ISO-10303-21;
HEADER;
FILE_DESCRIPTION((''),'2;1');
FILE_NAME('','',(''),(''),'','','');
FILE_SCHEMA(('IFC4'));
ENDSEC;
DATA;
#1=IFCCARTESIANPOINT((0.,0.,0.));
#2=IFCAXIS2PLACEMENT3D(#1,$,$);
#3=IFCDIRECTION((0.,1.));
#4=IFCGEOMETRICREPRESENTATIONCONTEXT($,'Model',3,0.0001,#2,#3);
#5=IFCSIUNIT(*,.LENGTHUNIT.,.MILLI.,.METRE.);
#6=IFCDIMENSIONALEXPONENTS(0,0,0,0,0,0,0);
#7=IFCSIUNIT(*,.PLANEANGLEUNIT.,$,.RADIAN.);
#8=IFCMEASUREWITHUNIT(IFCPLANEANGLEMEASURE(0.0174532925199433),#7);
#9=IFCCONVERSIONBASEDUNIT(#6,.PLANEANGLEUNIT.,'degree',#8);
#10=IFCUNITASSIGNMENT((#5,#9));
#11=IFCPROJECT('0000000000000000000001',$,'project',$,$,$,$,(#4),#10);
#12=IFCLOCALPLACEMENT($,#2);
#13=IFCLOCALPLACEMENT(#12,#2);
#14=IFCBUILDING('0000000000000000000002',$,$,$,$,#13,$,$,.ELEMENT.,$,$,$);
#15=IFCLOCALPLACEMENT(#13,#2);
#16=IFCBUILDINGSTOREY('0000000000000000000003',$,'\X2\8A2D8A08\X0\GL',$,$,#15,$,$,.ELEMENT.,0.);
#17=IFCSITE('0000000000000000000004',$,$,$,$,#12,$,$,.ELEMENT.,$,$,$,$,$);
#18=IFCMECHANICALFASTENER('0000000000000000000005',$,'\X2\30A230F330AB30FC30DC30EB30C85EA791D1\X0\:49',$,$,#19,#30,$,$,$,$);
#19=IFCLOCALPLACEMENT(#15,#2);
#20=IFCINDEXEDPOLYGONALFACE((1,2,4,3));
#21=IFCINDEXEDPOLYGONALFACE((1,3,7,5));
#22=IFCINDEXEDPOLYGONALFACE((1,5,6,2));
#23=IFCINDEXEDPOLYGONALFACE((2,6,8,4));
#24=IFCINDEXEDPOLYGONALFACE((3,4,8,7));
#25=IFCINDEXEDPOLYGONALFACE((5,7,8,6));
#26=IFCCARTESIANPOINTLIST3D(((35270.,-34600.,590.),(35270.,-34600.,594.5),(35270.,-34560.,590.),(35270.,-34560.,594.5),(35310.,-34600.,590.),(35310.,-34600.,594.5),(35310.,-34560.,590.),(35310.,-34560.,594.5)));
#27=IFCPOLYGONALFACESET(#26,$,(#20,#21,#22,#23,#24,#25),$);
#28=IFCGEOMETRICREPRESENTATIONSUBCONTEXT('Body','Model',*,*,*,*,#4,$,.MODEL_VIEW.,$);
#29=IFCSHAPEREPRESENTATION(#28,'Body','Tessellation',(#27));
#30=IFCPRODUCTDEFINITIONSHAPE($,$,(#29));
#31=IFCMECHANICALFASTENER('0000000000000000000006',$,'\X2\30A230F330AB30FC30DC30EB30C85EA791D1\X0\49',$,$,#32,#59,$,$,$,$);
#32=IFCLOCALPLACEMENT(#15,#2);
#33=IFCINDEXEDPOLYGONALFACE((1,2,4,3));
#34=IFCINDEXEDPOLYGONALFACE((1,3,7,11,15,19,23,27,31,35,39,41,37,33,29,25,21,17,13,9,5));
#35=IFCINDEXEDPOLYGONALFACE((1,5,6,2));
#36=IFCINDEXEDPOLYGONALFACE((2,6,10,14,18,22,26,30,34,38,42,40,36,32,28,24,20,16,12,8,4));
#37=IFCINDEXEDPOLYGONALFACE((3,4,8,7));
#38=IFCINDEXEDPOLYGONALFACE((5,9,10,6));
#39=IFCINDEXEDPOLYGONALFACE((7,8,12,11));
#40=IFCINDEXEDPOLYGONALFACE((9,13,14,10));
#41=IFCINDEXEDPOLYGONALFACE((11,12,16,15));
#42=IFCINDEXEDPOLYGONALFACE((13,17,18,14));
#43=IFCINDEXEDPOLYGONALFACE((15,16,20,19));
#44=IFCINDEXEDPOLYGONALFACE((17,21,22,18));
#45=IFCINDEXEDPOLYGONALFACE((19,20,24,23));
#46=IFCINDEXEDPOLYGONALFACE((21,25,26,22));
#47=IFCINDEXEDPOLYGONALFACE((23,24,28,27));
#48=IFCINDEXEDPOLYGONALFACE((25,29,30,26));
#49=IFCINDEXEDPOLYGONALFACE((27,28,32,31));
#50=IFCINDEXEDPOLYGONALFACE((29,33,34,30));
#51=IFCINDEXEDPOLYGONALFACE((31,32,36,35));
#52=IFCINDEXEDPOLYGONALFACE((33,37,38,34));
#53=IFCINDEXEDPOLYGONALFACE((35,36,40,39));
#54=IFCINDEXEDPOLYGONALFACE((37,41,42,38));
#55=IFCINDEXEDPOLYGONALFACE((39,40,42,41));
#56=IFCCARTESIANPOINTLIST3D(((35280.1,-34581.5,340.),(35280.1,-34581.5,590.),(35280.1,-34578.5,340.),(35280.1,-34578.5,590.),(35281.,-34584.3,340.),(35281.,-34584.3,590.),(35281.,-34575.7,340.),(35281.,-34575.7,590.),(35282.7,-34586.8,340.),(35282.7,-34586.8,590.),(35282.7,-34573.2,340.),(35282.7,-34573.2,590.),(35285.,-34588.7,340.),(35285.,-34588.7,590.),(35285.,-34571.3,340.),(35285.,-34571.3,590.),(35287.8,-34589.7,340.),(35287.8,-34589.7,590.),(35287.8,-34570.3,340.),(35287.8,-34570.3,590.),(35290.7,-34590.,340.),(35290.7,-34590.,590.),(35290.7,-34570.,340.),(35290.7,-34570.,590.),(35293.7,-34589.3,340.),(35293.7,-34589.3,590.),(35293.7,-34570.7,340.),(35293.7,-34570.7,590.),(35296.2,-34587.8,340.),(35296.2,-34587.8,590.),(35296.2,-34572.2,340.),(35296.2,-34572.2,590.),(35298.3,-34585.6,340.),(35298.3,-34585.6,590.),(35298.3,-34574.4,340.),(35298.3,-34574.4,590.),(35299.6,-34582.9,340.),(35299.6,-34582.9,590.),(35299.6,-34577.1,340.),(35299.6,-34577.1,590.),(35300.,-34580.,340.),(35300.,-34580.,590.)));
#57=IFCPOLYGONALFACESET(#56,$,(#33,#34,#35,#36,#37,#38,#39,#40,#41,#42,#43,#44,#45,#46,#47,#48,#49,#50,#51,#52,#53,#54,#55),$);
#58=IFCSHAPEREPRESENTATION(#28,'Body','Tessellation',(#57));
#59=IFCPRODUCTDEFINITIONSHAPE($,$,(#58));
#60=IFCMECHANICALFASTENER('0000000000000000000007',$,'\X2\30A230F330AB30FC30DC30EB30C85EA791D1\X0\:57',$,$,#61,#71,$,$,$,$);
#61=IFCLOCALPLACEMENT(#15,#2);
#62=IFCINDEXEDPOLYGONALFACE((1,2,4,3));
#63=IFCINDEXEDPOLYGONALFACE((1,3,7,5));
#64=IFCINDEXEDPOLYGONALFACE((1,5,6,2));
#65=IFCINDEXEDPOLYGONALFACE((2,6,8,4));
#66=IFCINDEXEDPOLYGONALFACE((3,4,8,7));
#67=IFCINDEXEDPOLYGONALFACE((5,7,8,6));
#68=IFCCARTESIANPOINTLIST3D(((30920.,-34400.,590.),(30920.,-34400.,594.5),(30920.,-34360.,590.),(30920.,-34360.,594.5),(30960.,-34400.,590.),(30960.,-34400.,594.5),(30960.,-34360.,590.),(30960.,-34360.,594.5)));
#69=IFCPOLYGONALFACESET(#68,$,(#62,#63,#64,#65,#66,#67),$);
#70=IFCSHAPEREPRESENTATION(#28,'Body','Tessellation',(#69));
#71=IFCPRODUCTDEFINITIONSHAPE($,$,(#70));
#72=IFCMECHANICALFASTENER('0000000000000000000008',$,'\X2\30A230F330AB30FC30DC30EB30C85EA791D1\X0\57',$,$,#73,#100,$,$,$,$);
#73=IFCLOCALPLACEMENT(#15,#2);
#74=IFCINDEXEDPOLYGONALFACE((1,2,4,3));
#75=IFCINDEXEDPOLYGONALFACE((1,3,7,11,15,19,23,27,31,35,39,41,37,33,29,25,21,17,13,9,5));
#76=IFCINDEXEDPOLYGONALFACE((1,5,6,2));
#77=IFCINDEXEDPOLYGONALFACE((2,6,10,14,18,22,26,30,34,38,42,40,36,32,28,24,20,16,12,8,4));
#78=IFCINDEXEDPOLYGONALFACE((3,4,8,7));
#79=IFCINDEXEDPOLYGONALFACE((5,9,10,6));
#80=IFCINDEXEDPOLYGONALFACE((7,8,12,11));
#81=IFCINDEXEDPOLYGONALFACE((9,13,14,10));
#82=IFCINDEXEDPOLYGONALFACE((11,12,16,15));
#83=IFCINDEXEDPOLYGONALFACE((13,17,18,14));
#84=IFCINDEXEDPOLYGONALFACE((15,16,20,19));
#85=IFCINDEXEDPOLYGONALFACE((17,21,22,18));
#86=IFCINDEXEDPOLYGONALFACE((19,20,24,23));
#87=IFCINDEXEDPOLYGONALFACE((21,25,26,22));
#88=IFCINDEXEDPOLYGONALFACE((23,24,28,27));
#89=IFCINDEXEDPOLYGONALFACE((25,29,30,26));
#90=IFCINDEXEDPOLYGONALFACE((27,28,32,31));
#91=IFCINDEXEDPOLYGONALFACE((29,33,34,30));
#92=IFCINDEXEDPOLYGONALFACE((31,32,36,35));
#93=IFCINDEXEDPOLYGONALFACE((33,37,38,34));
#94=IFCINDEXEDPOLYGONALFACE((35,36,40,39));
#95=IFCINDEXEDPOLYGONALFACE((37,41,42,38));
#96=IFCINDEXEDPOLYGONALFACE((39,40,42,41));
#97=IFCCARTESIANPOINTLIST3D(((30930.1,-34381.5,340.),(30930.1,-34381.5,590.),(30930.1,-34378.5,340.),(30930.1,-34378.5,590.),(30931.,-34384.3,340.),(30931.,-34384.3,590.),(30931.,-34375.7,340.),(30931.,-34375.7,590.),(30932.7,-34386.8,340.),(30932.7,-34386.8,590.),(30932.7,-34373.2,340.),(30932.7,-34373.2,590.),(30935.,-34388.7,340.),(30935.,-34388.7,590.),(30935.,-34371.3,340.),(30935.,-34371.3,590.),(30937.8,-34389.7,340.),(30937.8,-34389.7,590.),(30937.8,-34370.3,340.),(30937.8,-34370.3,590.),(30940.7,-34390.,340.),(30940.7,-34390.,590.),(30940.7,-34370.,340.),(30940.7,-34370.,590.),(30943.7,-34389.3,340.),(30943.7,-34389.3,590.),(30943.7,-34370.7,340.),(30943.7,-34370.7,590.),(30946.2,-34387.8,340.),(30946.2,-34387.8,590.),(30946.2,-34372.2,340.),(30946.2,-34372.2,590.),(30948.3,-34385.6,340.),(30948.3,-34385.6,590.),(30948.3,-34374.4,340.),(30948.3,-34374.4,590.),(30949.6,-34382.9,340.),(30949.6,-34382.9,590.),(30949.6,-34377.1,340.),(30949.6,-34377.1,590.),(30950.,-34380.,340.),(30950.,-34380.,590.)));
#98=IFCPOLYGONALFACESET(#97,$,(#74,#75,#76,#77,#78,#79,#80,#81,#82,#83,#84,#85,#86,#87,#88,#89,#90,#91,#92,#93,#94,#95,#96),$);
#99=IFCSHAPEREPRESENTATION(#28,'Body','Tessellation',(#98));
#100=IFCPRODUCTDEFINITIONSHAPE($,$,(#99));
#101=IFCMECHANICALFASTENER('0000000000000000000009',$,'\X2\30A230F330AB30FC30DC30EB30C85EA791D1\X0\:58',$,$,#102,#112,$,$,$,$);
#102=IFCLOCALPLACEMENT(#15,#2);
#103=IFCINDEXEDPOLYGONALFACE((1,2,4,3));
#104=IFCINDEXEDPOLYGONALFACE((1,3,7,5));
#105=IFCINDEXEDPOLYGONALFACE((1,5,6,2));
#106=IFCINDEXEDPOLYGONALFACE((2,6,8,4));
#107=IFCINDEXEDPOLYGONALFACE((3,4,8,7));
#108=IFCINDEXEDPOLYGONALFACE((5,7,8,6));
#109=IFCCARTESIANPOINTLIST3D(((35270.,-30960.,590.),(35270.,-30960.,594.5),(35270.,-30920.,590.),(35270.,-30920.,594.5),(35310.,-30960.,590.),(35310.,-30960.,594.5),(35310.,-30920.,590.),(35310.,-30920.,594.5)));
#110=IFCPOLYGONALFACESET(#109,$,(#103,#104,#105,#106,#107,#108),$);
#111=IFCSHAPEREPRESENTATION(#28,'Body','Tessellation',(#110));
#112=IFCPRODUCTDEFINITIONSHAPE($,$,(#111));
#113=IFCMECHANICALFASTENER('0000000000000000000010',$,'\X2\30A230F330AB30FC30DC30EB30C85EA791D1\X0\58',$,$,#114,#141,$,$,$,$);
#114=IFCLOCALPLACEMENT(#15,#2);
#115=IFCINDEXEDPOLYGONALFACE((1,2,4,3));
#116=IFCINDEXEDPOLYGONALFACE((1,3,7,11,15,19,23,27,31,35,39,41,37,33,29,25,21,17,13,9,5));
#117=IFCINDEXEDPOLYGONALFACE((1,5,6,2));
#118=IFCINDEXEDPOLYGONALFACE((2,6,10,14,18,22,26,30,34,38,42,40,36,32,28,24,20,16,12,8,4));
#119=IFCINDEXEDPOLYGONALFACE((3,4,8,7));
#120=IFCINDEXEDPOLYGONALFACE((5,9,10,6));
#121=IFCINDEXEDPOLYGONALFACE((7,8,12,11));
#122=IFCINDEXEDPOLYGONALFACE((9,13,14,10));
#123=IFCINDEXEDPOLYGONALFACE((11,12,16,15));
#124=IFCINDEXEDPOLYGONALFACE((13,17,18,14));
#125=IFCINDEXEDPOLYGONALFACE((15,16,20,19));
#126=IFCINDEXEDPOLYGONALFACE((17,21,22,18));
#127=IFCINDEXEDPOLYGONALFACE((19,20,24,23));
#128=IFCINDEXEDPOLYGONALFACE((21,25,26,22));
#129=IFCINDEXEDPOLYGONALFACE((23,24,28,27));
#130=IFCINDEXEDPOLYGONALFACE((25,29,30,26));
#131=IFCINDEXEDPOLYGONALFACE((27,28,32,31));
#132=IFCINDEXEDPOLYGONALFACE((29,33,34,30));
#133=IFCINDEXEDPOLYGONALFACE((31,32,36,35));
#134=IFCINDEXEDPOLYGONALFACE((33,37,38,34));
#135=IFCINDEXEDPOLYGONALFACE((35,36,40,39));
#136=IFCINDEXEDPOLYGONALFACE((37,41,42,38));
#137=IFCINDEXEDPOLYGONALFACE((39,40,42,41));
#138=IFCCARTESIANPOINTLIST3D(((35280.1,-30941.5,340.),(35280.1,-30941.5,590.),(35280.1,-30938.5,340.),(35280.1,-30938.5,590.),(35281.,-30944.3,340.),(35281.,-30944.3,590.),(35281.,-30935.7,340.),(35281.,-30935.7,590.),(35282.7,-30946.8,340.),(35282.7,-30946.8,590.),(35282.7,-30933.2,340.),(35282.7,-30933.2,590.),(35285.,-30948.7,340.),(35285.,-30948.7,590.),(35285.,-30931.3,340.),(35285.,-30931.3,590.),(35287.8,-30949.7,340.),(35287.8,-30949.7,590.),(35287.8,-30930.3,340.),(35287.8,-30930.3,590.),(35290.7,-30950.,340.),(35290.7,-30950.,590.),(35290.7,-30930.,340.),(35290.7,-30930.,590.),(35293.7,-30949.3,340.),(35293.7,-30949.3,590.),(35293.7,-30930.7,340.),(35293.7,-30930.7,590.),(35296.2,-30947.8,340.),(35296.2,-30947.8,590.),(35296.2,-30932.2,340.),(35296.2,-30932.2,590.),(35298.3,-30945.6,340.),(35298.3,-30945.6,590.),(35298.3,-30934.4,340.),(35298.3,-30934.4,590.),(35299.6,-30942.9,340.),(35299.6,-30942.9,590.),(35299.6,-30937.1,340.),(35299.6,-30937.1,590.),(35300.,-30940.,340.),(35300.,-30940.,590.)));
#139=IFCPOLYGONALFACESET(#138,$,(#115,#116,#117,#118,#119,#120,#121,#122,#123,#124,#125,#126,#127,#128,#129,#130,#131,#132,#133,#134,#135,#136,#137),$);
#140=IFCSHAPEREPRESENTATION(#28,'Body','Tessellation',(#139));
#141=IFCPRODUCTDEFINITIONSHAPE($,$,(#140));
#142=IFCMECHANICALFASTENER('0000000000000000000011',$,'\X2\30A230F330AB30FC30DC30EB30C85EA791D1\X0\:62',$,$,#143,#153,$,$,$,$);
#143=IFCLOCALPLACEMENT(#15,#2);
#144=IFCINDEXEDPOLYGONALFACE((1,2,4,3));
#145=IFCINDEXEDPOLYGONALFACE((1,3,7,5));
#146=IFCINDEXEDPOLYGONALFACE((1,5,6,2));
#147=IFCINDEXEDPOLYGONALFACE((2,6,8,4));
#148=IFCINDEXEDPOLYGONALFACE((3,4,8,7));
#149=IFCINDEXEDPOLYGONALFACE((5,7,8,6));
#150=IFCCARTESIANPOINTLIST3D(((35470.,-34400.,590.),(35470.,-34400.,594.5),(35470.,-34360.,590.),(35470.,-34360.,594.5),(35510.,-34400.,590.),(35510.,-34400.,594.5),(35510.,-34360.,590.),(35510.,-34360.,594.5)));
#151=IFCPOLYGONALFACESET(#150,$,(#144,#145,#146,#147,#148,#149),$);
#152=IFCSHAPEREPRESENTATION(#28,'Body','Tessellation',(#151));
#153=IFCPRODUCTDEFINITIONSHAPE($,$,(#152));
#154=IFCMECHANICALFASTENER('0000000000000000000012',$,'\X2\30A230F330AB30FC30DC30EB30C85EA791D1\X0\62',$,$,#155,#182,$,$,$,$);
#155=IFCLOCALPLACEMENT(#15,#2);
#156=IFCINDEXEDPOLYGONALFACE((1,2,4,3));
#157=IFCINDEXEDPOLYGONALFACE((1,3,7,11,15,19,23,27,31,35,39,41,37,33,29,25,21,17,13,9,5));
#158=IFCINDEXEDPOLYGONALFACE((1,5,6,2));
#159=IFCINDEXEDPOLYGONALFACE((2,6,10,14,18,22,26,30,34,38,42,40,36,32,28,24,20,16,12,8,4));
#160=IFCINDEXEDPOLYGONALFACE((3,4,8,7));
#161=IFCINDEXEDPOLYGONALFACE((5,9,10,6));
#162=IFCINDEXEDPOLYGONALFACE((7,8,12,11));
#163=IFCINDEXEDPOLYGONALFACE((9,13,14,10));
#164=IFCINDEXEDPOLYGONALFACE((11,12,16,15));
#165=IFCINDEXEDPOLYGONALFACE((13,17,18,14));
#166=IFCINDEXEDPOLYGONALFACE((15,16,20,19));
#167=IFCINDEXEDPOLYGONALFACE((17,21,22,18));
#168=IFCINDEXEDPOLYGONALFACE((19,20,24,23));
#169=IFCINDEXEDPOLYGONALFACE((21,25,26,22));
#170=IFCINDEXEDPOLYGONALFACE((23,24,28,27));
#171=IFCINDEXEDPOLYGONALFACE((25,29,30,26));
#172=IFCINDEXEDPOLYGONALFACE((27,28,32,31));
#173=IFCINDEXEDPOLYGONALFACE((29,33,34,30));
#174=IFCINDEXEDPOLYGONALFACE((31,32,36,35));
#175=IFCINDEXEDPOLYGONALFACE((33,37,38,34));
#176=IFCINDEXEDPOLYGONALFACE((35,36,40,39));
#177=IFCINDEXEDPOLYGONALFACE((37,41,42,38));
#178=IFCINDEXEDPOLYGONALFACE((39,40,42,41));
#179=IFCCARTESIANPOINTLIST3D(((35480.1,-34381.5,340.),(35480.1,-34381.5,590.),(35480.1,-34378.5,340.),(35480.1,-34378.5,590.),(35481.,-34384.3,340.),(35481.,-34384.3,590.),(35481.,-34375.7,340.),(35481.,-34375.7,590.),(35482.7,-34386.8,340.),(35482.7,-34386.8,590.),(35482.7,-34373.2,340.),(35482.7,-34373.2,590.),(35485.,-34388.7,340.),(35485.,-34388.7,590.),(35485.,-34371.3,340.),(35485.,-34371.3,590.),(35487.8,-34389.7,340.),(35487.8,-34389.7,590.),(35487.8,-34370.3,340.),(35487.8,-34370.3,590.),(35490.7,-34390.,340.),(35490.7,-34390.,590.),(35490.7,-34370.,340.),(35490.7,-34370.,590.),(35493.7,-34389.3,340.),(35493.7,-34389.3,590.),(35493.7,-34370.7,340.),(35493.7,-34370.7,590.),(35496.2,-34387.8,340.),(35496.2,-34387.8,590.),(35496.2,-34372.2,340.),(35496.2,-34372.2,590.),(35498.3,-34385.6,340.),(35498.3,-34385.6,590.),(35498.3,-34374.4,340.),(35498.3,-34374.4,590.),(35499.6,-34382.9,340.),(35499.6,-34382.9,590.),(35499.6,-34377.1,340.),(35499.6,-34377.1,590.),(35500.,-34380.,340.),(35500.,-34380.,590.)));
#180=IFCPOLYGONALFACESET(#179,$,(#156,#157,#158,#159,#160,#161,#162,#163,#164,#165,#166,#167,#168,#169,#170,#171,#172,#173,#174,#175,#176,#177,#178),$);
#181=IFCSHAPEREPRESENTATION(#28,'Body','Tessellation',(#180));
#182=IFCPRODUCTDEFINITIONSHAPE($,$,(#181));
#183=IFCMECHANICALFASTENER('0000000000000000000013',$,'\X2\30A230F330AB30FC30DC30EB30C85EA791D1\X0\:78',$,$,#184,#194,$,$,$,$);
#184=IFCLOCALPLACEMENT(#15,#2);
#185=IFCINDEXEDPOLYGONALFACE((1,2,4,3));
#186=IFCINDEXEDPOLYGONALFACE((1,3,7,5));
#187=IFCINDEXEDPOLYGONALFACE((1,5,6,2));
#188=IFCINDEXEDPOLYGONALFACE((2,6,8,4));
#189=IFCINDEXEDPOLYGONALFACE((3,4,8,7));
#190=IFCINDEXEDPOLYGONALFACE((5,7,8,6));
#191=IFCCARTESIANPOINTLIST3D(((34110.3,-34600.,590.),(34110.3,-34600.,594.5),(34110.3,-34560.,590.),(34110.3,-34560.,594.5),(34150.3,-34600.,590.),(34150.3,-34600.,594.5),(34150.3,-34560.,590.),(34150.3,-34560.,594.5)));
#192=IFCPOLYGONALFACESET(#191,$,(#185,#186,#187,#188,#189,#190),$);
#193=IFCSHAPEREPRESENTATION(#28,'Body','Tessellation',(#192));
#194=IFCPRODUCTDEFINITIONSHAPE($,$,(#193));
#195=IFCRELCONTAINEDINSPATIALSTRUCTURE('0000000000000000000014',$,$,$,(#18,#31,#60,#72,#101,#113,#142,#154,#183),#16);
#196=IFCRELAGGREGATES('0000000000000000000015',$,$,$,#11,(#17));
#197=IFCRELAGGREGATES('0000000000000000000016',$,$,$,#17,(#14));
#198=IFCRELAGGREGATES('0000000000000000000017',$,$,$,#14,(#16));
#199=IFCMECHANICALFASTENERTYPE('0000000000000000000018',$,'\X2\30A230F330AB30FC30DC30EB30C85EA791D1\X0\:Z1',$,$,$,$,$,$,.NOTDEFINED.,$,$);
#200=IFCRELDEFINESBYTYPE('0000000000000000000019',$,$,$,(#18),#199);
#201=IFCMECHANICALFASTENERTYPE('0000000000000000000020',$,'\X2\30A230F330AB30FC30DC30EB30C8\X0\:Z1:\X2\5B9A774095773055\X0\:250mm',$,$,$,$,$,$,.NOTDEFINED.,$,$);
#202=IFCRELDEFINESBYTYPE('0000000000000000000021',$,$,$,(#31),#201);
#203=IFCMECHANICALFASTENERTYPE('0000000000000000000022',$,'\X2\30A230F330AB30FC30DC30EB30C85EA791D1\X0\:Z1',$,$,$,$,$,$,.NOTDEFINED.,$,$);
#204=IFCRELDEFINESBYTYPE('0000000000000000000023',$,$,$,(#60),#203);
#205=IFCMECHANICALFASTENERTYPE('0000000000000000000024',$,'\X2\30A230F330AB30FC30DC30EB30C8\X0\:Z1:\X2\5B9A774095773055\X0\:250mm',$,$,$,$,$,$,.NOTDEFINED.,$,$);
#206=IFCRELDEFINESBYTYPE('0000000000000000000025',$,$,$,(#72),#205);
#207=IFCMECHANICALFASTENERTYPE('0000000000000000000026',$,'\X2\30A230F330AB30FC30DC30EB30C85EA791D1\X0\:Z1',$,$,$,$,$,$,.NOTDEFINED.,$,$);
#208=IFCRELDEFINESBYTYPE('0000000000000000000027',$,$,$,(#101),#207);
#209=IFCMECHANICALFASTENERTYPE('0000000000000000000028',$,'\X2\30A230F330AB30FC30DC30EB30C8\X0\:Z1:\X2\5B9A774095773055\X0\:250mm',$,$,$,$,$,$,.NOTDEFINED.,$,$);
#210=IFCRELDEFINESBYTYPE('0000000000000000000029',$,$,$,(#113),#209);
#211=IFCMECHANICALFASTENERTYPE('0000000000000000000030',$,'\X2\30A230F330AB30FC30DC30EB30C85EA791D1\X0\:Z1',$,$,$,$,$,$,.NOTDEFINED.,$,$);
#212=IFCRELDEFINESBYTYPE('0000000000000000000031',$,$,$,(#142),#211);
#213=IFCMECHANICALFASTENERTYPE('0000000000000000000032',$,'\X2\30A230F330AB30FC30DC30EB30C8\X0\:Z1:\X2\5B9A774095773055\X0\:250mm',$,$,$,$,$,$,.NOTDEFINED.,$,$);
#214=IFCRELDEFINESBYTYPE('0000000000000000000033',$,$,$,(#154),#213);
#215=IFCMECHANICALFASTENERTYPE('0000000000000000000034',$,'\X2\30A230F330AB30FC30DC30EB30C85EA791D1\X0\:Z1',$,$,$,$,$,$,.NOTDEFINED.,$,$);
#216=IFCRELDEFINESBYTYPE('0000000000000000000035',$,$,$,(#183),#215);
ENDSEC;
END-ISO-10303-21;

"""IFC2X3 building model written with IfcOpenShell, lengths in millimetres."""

from ifc_helpers import new_model, entity, si_unit, converted_unit, direction, frame, origin, origin_with_axes, origin_2d, place, context, subcontext, project, spatial, rectangle, circle, extrude, type_object, element, save


model = new_model("IFC2X3")

# Units and contexts
model_context = context("Model", 3, precision=0.0001, world=origin(), true_north=direction((0.0, 1.0)))
body_context = subcontext(model_context, "Body", "Model", "MODEL_VIEW")
ifc_project = project(units=[si_unit("LENGTHUNIT", "METRE", prefix="MILLI"), converted_unit("PLANEANGLEUNIT", "degree", entity("IfcPlaneAngleMeasure", 0.0174532925199433), si_unit("PLANEANGLEUNIT", "RADIAN"), dimensions=[0, 0, 0, 0, 0, 0, 0])], contexts=[model_context])

# Site, building, storey
site_placement = place(None, origin())
site = spatial("IfcSite", under=ifc_project, at=site_placement, CompositionType="ELEMENT")
building_placement = place(site_placement, origin())
building = spatial("IfcBuilding", under=site, at=building_placement, CompositionType="ELEMENT")
storey_placement = place(building_placement, origin())
storey = spatial("IfcBuildingStorey", under=building, at=storey_placement, Name="設計GL", CompositionType="ELEMENT", Elevation=0.0)

# Mechanical fasteners
mechanical_fastener_type_1 = type_object("IfcMechanicalFastenerType", Name="アンカーボルト座金:Z1")
mechanical_fastener_1_placement = place(storey_placement, frame((35290.0, -34580.0, 590.0)))
element("IfcMechanicalFastener", 1, at=mechanical_fastener_1_placement, inside=storey, type_object=mechanical_fastener_type_1, Name="アンカーボルト座金:49", context=body_context, shape_type="SweptSolid", body=[
    extrude(rectangle(XDim=40.0, YDim=40.0, at=origin_2d()), origin_with_axes(), (0.0, 0.0, 1.0), 4.5),
])
mechanical_fastener_type_2 = type_object("IfcMechanicalFastenerType", Name="アンカーボルト:Z1:定着長さ:250mm")
mechanical_fastener_2_placement = place(storey_placement, frame((35290.0, -34580.0, 340.0)))
element("IfcMechanicalFastener", 2, at=mechanical_fastener_2_placement, inside=storey, type_object=mechanical_fastener_type_2, Name="アンカーボルト座金49", context=body_context, shape_type="SweptSolid", body=[
    extrude(circle(Radius=10.0, at=origin_2d()), origin_with_axes(), (0.0, 0.0, 1.0), 250.0),
])
mechanical_fastener_type_3 = type_object("IfcMechanicalFastenerType", Name="アンカーボルト座金:Z1")
mechanical_fastener_3_placement = place(storey_placement, frame((30940.0, -34380.0, 590.0)))
element("IfcMechanicalFastener", 3, at=mechanical_fastener_3_placement, inside=storey, type_object=mechanical_fastener_type_3, Name="アンカーボルト座金:57", context=body_context, shape_type="SweptSolid", body=[
    extrude(rectangle(XDim=40.0, YDim=40.0, at=origin_2d()), origin_with_axes(), (0.0, 0.0, 1.0), 4.5),
])
mechanical_fastener_type_4 = type_object("IfcMechanicalFastenerType", Name="アンカーボルト:Z1:定着長さ:250mm")
mechanical_fastener_4_placement = place(storey_placement, frame((30940.0, -34380.0, 340.0)))
element("IfcMechanicalFastener", 4, at=mechanical_fastener_4_placement, inside=storey, type_object=mechanical_fastener_type_4, Name="アンカーボルト座金57", context=body_context, shape_type="SweptSolid", body=[
    extrude(circle(Radius=10.0, at=origin_2d()), origin_with_axes(), (0.0, 0.0, 1.0), 250.0),
])
mechanical_fastener_type_5 = type_object("IfcMechanicalFastenerType", Name="アンカーボルト座金:Z1")
mechanical_fastener_5_placement = place(storey_placement, frame((35290.0, -30940.0, 590.0)))
element("IfcMechanicalFastener", 5, at=mechanical_fastener_5_placement, inside=storey, type_object=mechanical_fastener_type_5, Name="アンカーボルト座金:58", context=body_context, shape_type="SweptSolid", body=[
    extrude(rectangle(XDim=40.0, YDim=40.0, at=origin_2d()), origin_with_axes(), (0.0, 0.0, 1.0), 4.5),
])
mechanical_fastener_type_6 = type_object("IfcMechanicalFastenerType", Name="アンカーボルト:Z1:定着長さ:250mm")
mechanical_fastener_6_placement = place(storey_placement, frame((35290.0, -30940.0, 340.0)))
element("IfcMechanicalFastener", 6, at=mechanical_fastener_6_placement, inside=storey, type_object=mechanical_fastener_type_6, Name="アンカーボルト座金58", context=body_context, shape_type="SweptSolid", body=[
    extrude(circle(Radius=10.0, at=origin_2d()), origin_with_axes(), (0.0, 0.0, 1.0), 250.0),
])
mechanical_fastener_type_7 = type_object("IfcMechanicalFastenerType", Name="アンカーボルト座金:Z1")
mechanical_fastener_7_placement = place(storey_placement, frame((35490.0, -34380.0, 590.0)))
element("IfcMechanicalFastener", 7, at=mechanical_fastener_7_placement, inside=storey, type_object=mechanical_fastener_type_7, Name="アンカーボルト座金:62", context=body_context, shape_type="SweptSolid", body=[
    extrude(rectangle(XDim=40.0, YDim=40.0, at=origin_2d()), origin_with_axes(), (0.0, 0.0, 1.0), 4.5),
])
mechanical_fastener_type_8 = type_object("IfcMechanicalFastenerType", Name="アンカーボルト:Z1:定着長さ:250mm")
mechanical_fastener_8_placement = place(storey_placement, frame((35490.0, -34380.0, 340.0)))
element("IfcMechanicalFastener", 8, at=mechanical_fastener_8_placement, inside=storey, type_object=mechanical_fastener_type_8, Name="アンカーボルト座金62", context=body_context, shape_type="SweptSolid", body=[
    extrude(circle(Radius=10.0, at=origin_2d()), origin_with_axes(), (0.0, 0.0, 1.0), 250.0),
])
mechanical_fastener_type_9 = type_object("IfcMechanicalFastenerType", Name="アンカーボルト座金:Z1")
mechanical_fastener_9_placement = place(storey_placement, frame((34130.3, -34580.0, 590.0)))
element("IfcMechanicalFastener", 9, at=mechanical_fastener_9_placement, inside=storey, type_object=mechanical_fastener_type_9, Name="アンカーボルト座金:78", context=body_context, shape_type="SweptSolid", body=[
    extrude(rectangle(XDim=40.0, YDim=40.0, at=origin_2d()), origin_with_axes(), (0.0, 0.0, 1.0), 4.5),
])

save(model, "model.ifc")
